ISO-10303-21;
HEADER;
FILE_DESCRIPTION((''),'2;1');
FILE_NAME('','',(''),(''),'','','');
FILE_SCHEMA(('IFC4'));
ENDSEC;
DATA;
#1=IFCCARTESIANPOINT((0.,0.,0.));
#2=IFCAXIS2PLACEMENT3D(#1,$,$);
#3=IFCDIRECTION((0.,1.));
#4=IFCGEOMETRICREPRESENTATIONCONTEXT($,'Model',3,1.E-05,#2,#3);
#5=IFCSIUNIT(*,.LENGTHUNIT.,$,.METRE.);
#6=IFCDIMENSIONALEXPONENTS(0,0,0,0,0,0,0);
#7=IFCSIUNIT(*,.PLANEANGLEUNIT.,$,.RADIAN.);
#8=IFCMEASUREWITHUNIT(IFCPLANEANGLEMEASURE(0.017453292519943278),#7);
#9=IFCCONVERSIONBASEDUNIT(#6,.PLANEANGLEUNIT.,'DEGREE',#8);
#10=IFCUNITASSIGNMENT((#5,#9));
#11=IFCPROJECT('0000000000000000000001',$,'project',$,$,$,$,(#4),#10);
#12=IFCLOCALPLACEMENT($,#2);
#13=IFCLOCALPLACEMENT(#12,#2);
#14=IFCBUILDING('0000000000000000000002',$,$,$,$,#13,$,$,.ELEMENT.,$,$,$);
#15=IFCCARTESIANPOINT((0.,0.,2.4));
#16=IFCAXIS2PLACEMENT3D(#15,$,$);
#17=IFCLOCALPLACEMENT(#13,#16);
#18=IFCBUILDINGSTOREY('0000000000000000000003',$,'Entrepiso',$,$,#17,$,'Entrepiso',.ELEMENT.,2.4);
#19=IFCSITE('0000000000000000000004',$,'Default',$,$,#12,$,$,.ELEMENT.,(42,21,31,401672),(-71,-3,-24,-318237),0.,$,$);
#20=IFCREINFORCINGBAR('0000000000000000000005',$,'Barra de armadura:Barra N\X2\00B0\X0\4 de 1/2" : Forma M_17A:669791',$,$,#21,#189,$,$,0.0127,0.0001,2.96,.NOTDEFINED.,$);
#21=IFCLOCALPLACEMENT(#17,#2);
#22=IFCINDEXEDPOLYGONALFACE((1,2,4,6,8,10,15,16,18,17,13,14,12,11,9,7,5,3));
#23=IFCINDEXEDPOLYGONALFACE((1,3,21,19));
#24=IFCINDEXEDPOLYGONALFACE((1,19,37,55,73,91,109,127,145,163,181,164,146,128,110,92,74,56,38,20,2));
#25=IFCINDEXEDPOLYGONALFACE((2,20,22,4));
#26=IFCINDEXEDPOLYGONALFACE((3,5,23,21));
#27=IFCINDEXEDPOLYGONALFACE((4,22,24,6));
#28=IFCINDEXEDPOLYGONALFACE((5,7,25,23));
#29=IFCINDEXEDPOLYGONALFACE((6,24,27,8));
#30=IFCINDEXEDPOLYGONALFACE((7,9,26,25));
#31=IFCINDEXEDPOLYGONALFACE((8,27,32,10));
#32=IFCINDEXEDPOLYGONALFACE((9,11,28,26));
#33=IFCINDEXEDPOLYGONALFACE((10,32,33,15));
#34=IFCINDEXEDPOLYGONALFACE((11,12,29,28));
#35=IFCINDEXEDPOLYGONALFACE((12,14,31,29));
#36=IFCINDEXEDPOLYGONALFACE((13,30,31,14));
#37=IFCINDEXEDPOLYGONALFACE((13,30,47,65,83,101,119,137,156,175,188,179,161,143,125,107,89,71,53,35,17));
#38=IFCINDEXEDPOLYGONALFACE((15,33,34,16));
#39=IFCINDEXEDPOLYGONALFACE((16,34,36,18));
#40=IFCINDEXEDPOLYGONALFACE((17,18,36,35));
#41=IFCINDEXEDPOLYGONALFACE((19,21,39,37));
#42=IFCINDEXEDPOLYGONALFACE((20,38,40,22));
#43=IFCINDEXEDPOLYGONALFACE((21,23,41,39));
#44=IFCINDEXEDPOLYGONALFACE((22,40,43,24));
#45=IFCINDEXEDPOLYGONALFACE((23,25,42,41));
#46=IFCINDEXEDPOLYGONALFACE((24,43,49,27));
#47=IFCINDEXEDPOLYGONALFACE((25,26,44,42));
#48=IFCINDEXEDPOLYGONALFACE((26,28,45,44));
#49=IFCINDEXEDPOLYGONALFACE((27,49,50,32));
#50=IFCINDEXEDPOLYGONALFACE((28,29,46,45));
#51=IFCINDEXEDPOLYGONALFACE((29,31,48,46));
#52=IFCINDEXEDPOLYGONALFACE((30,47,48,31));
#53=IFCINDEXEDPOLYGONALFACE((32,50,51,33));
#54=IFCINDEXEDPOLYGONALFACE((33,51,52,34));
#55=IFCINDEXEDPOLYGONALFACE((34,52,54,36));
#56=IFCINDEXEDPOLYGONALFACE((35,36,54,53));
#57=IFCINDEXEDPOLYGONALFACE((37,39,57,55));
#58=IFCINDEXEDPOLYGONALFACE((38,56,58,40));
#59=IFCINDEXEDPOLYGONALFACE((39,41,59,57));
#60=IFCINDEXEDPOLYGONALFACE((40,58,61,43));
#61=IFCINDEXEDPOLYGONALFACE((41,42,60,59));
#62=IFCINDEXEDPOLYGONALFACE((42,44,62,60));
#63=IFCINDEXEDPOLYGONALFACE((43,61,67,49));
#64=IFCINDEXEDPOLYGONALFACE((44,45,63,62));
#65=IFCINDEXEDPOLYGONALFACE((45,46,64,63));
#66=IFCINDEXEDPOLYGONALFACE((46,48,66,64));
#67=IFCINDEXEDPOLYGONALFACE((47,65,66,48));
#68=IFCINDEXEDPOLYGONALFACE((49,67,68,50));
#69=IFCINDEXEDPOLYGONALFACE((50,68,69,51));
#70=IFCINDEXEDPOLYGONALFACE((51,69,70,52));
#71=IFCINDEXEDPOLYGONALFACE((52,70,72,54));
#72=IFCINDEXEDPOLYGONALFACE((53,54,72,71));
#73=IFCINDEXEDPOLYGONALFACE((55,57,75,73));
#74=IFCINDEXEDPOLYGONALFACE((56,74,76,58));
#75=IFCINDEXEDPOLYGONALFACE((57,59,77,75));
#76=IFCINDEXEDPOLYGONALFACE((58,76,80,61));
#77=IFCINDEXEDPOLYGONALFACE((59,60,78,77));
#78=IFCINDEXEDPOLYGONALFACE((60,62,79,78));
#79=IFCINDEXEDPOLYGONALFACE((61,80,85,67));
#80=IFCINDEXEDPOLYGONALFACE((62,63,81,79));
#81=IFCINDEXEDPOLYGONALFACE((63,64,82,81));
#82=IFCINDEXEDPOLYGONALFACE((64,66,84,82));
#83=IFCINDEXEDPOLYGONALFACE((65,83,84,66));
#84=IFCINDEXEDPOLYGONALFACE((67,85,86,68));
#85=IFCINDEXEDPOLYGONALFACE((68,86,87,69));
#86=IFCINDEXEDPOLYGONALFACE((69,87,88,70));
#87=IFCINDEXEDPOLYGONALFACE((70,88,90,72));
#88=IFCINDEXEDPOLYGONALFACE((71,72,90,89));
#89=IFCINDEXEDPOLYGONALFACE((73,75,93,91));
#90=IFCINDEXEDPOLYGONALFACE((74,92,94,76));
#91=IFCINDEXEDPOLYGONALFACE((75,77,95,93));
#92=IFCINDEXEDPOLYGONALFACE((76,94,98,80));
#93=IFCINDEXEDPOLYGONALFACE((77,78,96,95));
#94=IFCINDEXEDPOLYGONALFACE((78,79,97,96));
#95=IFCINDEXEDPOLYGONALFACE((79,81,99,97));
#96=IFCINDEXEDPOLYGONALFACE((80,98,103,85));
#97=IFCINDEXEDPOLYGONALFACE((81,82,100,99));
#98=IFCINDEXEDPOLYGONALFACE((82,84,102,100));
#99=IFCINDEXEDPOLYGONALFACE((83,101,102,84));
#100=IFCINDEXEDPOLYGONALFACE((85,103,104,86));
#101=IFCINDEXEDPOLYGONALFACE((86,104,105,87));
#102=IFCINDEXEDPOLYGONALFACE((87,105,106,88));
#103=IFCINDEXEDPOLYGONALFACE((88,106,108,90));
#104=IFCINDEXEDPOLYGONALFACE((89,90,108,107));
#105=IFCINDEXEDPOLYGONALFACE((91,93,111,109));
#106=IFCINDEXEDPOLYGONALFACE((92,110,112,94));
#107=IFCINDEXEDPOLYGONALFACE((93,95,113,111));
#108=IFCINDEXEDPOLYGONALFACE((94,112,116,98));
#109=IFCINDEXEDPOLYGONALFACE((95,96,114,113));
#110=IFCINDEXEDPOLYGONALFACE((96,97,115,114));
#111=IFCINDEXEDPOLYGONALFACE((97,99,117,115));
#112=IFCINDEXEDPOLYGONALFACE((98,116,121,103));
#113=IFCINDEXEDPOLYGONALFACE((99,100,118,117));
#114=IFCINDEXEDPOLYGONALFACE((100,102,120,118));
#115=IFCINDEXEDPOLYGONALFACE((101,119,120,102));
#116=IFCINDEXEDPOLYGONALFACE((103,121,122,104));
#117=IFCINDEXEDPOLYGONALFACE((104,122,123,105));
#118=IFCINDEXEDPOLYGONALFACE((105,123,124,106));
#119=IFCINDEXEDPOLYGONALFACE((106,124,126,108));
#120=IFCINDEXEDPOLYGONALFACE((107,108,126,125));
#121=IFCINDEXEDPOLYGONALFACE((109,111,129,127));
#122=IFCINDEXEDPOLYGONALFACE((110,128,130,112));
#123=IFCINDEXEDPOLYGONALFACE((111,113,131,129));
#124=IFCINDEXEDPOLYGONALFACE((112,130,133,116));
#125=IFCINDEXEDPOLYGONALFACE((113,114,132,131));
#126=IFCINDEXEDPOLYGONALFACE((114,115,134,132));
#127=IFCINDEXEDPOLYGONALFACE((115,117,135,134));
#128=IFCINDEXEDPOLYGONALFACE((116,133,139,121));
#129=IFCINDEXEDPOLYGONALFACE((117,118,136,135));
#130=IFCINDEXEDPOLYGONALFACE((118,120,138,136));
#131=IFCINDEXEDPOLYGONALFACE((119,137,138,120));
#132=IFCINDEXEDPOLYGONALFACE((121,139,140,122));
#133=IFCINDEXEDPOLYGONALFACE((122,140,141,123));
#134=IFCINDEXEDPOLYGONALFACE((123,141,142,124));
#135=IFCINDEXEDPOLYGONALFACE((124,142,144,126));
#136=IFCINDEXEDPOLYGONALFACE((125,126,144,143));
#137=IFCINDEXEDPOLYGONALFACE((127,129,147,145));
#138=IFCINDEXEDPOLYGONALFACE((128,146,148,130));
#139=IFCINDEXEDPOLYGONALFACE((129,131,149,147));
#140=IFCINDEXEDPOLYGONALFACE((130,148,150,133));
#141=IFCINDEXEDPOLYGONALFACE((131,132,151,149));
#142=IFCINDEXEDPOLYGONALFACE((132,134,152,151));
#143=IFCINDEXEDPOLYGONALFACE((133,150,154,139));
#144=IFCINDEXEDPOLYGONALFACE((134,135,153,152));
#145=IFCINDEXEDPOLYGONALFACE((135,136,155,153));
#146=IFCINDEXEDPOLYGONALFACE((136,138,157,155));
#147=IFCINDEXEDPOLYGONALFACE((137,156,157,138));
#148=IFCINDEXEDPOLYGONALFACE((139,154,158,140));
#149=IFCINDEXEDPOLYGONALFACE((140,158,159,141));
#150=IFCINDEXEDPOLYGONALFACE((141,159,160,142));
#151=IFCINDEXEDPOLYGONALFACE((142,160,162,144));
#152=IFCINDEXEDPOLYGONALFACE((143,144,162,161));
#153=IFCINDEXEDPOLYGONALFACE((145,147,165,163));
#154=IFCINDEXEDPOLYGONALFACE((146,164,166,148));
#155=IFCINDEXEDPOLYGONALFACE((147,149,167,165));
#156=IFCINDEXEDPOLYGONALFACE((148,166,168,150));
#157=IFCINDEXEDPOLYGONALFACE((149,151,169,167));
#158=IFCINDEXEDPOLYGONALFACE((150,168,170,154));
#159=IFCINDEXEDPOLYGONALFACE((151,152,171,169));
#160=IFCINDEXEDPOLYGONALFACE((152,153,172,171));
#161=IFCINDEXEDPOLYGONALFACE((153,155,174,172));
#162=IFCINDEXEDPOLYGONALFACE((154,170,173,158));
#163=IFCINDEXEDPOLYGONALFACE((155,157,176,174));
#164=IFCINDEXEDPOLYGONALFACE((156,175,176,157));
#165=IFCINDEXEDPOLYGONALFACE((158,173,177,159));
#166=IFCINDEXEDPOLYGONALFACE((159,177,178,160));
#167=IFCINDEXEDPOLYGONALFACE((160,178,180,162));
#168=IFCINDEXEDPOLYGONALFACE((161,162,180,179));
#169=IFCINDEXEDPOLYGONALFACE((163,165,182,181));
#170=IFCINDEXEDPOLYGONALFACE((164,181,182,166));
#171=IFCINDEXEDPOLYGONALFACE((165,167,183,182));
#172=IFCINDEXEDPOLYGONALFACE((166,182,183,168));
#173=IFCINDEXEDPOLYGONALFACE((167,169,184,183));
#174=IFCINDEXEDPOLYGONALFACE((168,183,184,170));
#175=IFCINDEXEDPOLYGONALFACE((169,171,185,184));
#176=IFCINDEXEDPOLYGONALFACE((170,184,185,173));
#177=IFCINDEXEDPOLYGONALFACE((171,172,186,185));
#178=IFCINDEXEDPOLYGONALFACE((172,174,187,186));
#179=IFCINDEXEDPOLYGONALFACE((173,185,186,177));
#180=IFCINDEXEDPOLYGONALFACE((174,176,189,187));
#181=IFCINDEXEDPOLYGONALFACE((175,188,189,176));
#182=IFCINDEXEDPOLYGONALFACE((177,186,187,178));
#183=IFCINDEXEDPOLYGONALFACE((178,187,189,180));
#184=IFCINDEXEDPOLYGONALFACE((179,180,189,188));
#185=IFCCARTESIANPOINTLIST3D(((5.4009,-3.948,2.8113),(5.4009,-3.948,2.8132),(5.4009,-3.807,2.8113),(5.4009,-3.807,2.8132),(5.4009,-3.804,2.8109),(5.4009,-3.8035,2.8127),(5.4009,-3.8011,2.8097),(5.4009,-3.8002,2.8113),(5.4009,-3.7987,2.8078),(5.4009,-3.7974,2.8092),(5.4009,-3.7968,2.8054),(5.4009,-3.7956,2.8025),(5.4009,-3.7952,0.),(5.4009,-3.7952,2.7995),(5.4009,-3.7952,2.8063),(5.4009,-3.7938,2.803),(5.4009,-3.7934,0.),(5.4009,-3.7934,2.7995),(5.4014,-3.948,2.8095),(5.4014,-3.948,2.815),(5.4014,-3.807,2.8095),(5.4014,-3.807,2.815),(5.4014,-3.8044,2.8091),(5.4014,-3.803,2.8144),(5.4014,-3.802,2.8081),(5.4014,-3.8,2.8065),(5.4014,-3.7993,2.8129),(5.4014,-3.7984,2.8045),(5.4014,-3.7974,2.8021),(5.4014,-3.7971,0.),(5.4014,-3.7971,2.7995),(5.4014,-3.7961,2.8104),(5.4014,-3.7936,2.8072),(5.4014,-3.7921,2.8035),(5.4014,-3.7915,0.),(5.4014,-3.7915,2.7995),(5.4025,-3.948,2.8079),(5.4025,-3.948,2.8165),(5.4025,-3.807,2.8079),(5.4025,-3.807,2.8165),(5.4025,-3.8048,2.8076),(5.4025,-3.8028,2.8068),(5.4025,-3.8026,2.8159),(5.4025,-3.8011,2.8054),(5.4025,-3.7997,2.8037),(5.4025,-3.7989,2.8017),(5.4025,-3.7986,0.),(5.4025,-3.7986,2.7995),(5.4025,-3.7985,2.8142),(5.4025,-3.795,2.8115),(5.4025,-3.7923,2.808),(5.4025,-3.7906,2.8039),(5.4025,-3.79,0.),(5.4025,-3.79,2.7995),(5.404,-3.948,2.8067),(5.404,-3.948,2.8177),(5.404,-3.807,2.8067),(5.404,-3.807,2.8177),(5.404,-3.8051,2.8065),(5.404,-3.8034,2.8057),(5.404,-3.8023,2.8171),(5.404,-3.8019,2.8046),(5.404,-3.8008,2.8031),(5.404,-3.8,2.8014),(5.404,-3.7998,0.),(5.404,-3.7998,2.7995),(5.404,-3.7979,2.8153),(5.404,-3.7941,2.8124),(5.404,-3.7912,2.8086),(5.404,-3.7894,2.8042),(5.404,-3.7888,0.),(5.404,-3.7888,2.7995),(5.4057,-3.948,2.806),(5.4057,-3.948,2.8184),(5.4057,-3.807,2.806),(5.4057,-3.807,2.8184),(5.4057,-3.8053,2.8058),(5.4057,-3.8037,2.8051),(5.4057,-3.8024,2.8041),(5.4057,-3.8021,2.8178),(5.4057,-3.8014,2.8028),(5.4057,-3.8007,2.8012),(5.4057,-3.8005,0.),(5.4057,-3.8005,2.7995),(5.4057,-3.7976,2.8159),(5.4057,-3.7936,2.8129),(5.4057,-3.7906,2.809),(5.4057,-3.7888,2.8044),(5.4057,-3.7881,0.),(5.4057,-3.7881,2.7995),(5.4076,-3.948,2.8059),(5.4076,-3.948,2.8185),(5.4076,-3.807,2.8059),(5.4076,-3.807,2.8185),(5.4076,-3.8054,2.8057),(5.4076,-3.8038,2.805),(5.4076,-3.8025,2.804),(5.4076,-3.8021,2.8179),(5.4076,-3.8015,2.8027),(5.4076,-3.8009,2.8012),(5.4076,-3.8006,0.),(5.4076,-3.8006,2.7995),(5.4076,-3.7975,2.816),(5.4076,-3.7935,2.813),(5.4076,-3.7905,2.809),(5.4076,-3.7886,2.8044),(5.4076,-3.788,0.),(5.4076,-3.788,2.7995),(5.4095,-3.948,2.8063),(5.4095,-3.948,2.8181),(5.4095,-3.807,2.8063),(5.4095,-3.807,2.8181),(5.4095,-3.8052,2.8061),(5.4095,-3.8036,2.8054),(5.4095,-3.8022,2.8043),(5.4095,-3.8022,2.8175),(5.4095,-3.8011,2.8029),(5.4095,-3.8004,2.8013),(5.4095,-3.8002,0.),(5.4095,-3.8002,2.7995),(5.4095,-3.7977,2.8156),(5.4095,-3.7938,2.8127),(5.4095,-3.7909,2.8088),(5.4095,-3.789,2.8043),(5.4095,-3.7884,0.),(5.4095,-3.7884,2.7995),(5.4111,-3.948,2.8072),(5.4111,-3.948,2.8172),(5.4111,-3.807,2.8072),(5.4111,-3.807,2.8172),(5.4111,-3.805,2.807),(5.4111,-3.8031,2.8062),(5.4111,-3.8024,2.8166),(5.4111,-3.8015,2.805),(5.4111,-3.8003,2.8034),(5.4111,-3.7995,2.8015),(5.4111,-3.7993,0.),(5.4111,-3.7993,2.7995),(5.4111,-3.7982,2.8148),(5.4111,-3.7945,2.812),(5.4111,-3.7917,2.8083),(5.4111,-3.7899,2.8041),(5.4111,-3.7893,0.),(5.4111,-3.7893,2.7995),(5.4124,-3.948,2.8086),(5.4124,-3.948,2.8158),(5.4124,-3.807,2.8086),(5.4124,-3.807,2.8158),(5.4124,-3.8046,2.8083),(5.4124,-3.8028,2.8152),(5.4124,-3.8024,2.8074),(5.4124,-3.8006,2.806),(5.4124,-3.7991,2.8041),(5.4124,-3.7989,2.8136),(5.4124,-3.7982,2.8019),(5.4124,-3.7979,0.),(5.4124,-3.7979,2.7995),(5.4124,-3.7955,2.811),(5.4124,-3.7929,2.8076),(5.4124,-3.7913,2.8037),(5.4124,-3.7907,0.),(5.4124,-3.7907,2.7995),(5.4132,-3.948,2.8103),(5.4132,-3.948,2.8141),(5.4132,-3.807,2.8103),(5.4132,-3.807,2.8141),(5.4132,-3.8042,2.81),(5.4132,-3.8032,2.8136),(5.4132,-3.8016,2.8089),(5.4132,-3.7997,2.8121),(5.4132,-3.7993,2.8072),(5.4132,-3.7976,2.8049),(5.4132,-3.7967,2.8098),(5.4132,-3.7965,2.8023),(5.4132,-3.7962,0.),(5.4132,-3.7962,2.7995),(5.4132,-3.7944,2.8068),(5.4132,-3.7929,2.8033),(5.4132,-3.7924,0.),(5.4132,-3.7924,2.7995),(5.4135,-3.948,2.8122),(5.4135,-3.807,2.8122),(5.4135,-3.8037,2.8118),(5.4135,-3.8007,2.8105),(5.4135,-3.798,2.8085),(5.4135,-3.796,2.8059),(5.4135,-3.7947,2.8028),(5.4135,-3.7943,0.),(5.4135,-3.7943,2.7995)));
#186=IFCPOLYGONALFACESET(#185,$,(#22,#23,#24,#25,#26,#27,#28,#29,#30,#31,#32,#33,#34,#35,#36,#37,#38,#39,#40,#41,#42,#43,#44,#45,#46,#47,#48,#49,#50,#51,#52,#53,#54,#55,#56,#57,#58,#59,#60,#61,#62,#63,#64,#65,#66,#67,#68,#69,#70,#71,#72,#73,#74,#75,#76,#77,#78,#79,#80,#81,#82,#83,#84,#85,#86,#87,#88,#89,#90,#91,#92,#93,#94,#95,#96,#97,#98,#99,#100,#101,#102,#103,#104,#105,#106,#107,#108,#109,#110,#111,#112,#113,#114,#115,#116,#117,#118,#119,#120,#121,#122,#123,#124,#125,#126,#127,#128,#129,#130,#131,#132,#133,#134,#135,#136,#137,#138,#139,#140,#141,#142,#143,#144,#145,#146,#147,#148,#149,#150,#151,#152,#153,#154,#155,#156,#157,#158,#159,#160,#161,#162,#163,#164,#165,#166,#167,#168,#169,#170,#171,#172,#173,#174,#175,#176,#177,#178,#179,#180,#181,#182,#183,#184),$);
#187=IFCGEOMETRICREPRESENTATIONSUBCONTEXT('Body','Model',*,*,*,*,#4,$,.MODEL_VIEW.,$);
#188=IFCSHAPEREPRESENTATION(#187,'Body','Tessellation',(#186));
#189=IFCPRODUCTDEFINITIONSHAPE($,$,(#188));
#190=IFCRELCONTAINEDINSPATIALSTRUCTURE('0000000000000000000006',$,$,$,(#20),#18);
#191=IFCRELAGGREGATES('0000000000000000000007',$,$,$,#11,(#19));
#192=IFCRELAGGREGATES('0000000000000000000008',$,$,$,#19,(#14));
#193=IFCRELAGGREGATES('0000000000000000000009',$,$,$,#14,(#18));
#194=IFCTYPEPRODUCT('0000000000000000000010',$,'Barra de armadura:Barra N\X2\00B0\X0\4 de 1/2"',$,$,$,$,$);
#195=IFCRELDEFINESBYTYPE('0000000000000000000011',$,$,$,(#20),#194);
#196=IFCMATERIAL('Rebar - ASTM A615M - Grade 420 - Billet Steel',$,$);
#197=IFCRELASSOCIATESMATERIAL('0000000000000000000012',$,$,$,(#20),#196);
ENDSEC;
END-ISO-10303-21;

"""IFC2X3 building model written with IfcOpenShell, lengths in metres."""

from ifc_helpers import new_model, entity, si_unit, converted_unit, direction, frame, origin, place, context, subcontext, project, spatial, material, type_object, element, save


model = new_model("IFC2X3")

# Units and contexts
model_context = context("Model", 3, precision=1e-05, world=origin(), true_north=direction((0.0, 1.0)))
body_context = subcontext(model_context, "Body", "Model", "MODEL_VIEW")
ifc_project = project(units=[si_unit("LENGTHUNIT", "METRE"), converted_unit("PLANEANGLEUNIT", "DEGREE", entity("IfcPlaneAngleMeasure", 0.017453292519943278), si_unit("PLANEANGLEUNIT", "RADIAN"), dimensions=[0, 0, 0, 0, 0, 0, 0])], contexts=[model_context])

# Site, building, storey
site_placement = place(None, origin())
site = spatial("IfcSite", under=ifc_project, at=site_placement, Name="Default", CompositionType="ELEMENT", RefLatitude=(42, 21, 31, 401672), RefLongitude=(-71, -3, -24, -318237), RefElevation=0.0)
building_placement = place(site_placement, origin())
building = spatial("IfcBuilding", under=site, at=building_placement, CompositionType="ELEMENT")
storey_placement = place(building_placement, frame((0.0, 0.0, 2.4)))
storey = spatial("IfcBuildingStorey", under=building, at=storey_placement, Name="Entrepiso", LongName="Entrepiso", CompositionType="ELEMENT", Elevation=2.4)

# Reinforcing bar
ifc_material = material(Name="Rebar - ASTM A615M - Grade 420 - Billet Steel")
type_product_1 = type_object("IfcTypeProduct", Name="Barra de armadura:Barra N°4 de 1/2\"")
reinforcing_bar_1_placement = place(storey_placement, origin())
element("IfcReinforcingBar", 1, at=reinforcing_bar_1_placement, inside=storey, type_object=type_product_1, material=ifc_material, Name="Barra de armadura:Barra N°4 de 1/2\" : Forma M_17A:669791", BarLength=2.96, BarRole="NOTDEFINED", CrossSectionArea=0.0001, NominalDiameter=0.0127, context=body_context, shape_type="AdvancedSweptSolid", body=[
    entity("IfcSweptDiskSolid", entity("IfcCompositeCurve", [entity("IfcCompositeCurveSegment", "CONTINUOUS", True, entity("IfcPolyline", [entity("IfcCartesianPoint", [5.4071, -3.7943, 0.0]), entity("IfcCartesianPoint", [5.4071, -3.7943, 2.7995])])), entity("IfcCompositeCurveSegment", "CONTINUOUS", True, entity("IfcTrimmedCurve", entity("IfcCircle", entity("IfcAxis2Placement3D", entity("IfcCartesianPoint", [5.4071, -3.807, 2.7995]), entity("IfcDirection", [1.0, 0.0, 0.0]), entity("IfcDirection", [0.0, 0.0, 1.0])), 0.0127), [entity("IfcParameterValue", 270.0)], [entity("IfcParameterValue", 360.0)], True, "PARAMETER")), entity("IfcCompositeCurveSegment", "CONTINUOUS", True, entity("IfcPolyline", [entity("IfcCartesianPoint", [5.4071, -3.807, 2.8122]), entity("IfcCartesianPoint", [5.4071, -3.948, 2.8122])]))], False), 0.0063, None, 0.0, 92.0),
])

save(model, "model.ifc")
